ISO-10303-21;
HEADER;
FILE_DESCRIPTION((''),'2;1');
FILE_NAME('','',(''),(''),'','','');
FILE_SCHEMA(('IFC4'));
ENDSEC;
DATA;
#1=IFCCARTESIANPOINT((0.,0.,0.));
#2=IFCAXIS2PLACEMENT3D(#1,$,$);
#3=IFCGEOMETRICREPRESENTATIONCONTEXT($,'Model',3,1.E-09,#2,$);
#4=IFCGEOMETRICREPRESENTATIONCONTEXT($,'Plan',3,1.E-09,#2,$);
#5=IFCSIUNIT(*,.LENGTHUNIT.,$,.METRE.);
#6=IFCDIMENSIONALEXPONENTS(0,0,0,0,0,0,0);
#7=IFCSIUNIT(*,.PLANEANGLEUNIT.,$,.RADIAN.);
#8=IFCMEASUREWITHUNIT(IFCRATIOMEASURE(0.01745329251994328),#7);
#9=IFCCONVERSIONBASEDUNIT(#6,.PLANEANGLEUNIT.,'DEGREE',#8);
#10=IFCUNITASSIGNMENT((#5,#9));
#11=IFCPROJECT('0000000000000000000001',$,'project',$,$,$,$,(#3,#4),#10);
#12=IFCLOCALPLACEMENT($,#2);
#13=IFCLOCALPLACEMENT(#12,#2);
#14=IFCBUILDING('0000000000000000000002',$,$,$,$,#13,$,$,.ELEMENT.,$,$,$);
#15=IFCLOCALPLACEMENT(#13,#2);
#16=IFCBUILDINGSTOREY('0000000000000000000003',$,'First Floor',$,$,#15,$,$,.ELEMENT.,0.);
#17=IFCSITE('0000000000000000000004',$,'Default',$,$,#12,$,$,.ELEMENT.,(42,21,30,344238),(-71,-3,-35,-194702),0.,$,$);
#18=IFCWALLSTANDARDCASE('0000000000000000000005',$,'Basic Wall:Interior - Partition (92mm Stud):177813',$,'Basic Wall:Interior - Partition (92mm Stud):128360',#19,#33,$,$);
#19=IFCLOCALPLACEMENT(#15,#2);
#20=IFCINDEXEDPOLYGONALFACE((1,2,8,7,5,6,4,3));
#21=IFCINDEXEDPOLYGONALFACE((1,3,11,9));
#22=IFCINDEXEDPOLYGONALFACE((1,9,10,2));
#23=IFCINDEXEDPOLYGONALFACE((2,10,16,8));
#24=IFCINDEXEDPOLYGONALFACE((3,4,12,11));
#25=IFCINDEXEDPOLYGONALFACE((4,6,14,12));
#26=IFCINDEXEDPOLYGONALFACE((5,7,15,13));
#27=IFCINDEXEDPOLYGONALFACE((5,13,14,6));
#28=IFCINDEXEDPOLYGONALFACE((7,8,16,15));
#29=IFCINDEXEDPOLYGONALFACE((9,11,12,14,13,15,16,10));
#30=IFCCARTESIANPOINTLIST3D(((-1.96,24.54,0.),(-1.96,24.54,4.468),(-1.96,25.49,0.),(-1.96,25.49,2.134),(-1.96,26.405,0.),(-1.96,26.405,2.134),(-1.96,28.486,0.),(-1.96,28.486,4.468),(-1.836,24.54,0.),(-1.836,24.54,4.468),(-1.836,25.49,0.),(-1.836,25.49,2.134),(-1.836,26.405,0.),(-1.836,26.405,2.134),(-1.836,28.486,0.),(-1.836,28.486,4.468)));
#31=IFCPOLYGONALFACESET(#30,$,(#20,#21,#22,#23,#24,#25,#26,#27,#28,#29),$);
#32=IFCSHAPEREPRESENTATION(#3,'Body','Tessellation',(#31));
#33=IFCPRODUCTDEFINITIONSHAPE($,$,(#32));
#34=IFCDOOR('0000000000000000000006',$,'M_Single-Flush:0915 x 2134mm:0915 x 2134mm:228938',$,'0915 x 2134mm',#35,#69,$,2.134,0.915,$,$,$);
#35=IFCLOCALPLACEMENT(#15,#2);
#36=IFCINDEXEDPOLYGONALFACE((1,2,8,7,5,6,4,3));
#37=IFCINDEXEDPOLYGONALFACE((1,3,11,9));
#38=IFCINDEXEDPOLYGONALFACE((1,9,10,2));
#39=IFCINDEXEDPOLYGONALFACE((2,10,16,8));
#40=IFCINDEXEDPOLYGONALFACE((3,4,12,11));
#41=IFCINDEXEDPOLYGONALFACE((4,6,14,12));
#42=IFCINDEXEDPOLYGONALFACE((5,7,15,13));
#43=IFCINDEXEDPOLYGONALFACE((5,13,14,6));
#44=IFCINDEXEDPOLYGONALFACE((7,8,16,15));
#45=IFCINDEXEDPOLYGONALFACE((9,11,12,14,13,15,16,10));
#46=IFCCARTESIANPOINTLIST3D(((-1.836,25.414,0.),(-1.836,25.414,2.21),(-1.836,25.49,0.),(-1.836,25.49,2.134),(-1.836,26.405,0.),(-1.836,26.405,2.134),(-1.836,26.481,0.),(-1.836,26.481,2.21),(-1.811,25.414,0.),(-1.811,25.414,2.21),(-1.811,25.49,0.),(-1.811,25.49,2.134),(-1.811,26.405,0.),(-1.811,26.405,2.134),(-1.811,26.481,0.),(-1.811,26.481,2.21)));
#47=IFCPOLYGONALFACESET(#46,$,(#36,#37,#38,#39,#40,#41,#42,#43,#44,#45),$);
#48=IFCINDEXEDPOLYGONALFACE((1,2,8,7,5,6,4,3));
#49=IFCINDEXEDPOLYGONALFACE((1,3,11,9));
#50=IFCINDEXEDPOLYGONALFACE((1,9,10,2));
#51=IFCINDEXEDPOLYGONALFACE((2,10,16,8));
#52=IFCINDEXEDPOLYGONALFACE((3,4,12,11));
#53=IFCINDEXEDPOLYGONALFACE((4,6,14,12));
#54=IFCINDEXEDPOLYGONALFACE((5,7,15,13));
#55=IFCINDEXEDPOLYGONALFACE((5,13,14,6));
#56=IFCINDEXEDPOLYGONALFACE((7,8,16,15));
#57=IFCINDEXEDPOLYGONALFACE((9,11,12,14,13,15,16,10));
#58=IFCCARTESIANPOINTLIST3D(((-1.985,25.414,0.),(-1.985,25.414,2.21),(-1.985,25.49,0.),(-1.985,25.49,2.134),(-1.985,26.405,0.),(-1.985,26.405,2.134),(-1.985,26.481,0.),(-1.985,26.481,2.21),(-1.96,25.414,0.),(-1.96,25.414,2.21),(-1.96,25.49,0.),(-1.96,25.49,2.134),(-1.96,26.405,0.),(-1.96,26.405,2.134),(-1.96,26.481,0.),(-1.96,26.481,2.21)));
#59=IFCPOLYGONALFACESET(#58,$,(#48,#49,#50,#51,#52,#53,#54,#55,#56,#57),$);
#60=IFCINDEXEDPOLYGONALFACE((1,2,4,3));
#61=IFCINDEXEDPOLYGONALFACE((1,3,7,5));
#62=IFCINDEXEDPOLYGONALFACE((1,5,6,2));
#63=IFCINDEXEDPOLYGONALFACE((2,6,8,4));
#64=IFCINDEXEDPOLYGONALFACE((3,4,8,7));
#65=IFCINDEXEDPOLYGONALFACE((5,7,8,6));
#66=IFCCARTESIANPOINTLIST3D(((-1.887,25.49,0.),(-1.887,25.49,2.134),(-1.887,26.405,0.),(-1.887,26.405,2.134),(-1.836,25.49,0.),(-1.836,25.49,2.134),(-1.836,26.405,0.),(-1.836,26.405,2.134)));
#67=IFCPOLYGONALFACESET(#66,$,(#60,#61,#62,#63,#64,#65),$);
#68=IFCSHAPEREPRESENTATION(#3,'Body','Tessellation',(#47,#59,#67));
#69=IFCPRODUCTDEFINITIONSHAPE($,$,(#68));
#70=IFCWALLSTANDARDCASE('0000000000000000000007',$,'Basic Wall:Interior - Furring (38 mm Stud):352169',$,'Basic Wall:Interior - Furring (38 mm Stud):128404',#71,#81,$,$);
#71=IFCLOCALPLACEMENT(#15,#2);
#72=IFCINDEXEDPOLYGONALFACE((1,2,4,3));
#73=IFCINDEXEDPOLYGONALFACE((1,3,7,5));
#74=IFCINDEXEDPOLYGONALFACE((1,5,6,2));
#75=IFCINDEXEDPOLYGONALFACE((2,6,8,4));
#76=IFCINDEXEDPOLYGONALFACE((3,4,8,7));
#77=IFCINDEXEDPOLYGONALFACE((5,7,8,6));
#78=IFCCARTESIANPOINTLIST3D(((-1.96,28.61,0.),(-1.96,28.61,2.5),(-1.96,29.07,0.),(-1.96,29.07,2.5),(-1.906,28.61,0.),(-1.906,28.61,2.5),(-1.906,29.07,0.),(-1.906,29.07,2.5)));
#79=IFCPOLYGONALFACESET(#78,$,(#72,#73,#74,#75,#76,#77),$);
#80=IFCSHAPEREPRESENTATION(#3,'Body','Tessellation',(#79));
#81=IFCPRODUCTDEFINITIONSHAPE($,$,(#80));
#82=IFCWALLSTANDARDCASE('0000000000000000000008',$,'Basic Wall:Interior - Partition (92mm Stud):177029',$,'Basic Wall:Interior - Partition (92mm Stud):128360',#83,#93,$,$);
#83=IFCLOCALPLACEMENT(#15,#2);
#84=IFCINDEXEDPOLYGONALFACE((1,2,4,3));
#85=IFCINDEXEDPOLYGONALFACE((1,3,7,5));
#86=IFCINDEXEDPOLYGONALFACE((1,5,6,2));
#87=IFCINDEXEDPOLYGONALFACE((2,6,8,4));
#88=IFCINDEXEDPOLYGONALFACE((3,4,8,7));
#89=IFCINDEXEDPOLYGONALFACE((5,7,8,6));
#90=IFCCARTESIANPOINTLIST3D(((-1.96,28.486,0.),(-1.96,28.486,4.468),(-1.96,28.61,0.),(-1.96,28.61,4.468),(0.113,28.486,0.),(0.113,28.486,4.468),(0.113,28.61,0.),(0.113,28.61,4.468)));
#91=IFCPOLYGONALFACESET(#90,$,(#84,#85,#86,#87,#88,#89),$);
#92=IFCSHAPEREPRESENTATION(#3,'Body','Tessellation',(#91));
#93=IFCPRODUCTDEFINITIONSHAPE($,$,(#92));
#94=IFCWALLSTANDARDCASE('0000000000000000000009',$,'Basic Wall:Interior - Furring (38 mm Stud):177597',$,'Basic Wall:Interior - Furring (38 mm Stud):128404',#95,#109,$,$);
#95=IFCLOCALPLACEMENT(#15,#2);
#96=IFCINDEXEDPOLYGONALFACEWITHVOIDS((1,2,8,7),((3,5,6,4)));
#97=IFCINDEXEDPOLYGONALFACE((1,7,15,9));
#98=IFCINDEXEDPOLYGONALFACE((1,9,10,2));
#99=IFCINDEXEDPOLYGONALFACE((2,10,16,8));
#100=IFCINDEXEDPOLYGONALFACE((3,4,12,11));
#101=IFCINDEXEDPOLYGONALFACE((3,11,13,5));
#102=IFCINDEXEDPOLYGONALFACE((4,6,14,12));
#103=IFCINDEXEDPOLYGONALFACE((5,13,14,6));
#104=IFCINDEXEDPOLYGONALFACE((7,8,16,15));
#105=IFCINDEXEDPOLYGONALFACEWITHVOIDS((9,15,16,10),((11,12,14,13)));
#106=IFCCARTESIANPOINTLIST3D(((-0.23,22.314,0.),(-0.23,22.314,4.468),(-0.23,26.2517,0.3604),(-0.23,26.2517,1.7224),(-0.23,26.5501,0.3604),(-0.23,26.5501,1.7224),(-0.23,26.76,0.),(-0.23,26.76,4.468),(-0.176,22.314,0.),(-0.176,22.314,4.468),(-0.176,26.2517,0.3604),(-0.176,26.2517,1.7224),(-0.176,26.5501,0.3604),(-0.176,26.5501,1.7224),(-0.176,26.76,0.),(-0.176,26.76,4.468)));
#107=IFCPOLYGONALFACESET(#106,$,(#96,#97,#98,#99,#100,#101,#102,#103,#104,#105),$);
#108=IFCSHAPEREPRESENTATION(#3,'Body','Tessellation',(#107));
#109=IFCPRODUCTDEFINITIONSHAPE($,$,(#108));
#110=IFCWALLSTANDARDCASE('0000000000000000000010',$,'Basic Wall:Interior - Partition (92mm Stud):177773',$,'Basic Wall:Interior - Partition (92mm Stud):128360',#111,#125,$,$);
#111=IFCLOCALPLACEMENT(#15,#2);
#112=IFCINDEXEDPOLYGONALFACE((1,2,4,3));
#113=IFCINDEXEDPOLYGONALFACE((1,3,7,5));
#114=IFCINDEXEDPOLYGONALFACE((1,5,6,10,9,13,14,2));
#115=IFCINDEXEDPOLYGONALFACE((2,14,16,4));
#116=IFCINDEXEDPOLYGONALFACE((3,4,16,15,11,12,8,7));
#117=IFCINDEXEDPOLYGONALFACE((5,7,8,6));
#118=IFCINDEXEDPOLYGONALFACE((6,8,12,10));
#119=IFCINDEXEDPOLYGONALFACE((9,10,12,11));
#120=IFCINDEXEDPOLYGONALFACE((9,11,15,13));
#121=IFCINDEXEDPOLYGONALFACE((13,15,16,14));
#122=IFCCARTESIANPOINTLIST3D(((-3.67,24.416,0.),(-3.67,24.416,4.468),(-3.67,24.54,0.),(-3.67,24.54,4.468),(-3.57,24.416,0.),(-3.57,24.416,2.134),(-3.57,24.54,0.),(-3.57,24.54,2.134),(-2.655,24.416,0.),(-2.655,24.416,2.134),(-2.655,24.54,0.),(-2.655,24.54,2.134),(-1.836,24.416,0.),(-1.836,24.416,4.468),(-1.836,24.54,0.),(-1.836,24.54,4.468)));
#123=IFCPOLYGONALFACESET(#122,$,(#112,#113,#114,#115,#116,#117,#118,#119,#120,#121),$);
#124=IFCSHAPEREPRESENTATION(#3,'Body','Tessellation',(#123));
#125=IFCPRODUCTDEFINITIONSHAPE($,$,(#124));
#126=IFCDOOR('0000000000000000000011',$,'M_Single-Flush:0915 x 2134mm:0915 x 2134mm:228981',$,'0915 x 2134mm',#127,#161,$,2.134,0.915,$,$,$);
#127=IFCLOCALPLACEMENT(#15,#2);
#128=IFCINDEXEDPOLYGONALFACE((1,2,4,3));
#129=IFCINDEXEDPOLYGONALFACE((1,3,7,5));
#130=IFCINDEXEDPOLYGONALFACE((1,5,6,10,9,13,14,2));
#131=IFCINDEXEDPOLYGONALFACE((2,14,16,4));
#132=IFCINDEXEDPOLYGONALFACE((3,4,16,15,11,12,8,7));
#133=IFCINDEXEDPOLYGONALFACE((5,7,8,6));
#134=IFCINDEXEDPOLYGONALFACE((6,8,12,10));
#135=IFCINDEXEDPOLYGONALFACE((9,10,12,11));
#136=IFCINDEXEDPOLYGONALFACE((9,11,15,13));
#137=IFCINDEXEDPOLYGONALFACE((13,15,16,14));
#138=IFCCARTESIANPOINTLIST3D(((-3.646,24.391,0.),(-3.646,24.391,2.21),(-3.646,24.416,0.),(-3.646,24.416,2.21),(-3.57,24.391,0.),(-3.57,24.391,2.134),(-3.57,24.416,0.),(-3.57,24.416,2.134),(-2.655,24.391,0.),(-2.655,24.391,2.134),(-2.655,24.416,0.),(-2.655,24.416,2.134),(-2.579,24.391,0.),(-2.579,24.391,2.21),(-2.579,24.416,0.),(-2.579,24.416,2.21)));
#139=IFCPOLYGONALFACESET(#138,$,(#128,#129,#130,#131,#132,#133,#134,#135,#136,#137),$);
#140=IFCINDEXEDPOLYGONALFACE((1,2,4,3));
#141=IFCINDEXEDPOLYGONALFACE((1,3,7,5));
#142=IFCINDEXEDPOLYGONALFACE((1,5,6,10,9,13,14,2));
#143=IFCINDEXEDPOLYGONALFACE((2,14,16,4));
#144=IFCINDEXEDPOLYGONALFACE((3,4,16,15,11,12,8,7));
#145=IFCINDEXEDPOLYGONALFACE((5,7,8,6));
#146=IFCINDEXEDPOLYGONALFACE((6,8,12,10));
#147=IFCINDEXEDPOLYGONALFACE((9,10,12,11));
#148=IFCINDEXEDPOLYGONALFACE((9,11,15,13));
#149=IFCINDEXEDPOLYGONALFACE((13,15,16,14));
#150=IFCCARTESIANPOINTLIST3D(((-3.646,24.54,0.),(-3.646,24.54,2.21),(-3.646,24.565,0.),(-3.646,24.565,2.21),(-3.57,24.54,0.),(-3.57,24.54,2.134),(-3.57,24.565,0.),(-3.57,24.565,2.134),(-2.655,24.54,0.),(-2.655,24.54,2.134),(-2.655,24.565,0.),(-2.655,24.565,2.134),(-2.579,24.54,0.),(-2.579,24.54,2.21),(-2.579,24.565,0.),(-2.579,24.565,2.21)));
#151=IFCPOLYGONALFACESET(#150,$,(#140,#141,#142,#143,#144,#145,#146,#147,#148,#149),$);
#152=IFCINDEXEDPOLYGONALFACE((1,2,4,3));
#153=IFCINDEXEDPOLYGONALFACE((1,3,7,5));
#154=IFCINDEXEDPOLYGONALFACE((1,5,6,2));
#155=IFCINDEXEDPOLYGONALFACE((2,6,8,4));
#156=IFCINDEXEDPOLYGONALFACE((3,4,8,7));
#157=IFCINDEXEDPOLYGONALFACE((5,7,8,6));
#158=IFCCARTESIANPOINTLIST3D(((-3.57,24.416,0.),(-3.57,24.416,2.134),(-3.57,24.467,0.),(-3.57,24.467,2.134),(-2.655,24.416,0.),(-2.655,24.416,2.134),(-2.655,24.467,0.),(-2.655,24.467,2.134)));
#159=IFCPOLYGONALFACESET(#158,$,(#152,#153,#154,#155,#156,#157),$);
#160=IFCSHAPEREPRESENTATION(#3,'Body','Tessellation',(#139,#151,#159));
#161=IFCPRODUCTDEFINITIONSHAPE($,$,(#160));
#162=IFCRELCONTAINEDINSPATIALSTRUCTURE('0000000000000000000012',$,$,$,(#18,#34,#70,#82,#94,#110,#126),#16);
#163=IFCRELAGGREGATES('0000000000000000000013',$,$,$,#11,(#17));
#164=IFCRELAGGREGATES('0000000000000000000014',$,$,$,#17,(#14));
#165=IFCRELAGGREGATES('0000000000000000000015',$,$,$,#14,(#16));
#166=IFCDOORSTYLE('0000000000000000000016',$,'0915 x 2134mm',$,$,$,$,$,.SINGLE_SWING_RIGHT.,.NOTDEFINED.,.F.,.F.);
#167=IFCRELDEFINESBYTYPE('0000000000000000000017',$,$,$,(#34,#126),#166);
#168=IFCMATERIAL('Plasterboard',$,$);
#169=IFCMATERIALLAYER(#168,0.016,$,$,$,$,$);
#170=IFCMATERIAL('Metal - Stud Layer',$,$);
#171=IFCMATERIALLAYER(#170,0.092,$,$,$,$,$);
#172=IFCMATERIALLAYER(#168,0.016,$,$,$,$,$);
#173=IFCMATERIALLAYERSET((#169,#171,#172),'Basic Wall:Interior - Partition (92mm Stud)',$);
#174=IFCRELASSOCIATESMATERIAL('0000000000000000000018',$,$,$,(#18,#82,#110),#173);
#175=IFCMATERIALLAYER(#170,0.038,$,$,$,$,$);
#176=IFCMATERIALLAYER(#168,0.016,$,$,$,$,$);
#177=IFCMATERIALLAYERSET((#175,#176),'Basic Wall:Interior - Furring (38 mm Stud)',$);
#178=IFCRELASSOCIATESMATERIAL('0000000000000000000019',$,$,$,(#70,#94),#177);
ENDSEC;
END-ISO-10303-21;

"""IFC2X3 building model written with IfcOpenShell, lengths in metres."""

from ifc_helpers import new_model, entity, si_unit, converted_unit, frame, frame_2d, origin, origin_2d_with_axis, place, context, project, spatial, polyline, rectangle, outline, extrude, source, transform, mapped, material, layer, layer_set, layer_usage, type_object, type_shapes, element, fill, save


model = new_model("IFC2X3")

# Units and contexts
model_context = context("Model", 3, precision=1e-09, world=origin())
plan_context = context("Plan", 3, precision=1e-09, world=origin())
ifc_project = project(units=[si_unit("LENGTHUNIT", "METRE"), converted_unit("PLANEANGLEUNIT", "DEGREE", entity("IfcRatioMeasure", 0.01745329251994328), si_unit("PLANEANGLEUNIT", "RADIAN"), dimensions=[0, 0, 0, 0, 0, 0, 0])], contexts=[model_context, plan_context])

# Site, building, storey
site_placement = place(None, origin())
site = spatial("IfcSite", under=ifc_project, at=site_placement, Name="Default", CompositionType="ELEMENT", RefLatitude=(42, 21, 30, 344238), RefLongitude=(-71, -3, -35, -194702), RefElevation=0.0)
building_placement = place(site_placement, origin())
building = spatial("IfcBuilding", under=site, at=building_placement, CompositionType="ELEMENT")
storey_placement = place(building_placement, origin())
storey = spatial("IfcBuildingStorey", under=building, at=storey_placement, Name="First Floor", CompositionType="ELEMENT", Elevation=0.0)

# Wall, opening, door
ifc_material_1 = material(Name="Plasterboard")
ifc_layer_1 = layer(ifc_material_1, 0.016)
ifc_material_2 = material(Name="Metal - Stud Layer")
ifc_layer_2 = layer(ifc_material_2, 0.092)
ifc_layer_3 = layer(ifc_material_1, 0.016)
ifc_layer_set_1 = layer_set([ifc_layer_1, ifc_layer_2, ifc_layer_3], Name="Basic Wall:Interior - Partition (92mm Stud)")
ifc_layer_usage_1 = layer_usage(ifc_layer_set_1, "AXIS2", "NEGATIVE", 0.062)
wall_1_placement = place(storey_placement, frame((-1.898, 24.54, 0.0), z_axis=(0.0, 0.0, 1.0), x_axis=(0.0, 1.0, 0.0)))
wall_1 = element("IfcWallStandardCase", 1, at=wall_1_placement, inside=storey, material=ifc_layer_usage_1, Name="Basic Wall:Interior - Partition (92mm Stud):177813", ObjectType="Basic Wall:Interior - Partition (92mm Stud):128360", context=model_context, shape_type="SweptSolid", body=[
    extrude(rectangle(XDim=3.946, YDim=0.124, at=frame_2d((1.973, 0.0), x_axis=(-1.0, 0.0))), origin(), (0.0, 0.0, 1.0), 4.468),
])
opening_1_placement = place(wall_1_placement, frame((1.865, 0.062, 0.0)))
opening_1 = element("IfcOpeningElement", 2, at=opening_1_placement, cuts=wall_1, ObjectType="Opening", context=model_context, shape_type="SweptSolid", body=[
    extrude(rectangle(XDim=0.915, YDim=2.134, at=frame_2d((1.067, 0.4575), x_axis=(0.0, 1.0))), frame((0.0, 0.0, 0.0), z_axis=(0.0, -1.0, 0.0), x_axis=(0.0, 0.0, 1.0)), (0.0, 0.0, 1.0), 0.124),
])
door_style = type_object("IfcDoorStyle", Name="0915 x 2134mm", ConstructionType="NOTDEFINED", OperationType="SINGLE_SWING_RIGHT", ParameterTakesPrecedence=False, Sizeable=False)
shared_shape_1 = source(origin(), model_context, "Body", "SweptSolid", [
    extrude(outline(polyline([(-0.5335, -1.124), (0.5335, -1.124), (0.5335, 1.086), (0.4575, 1.086), (0.4575, -1.048), (-0.4575, -1.048), (-0.4575, 1.086), (-0.5335, 1.086), (-0.5335, -1.124)])), frame((0.4575, 0.124, 1.086), z_axis=(0.0, 1.0, 0.0), x_axis=(1.0, 0.0, 0.0)), (0.0, 0.0, 1.0), 0.025),
    extrude(outline(polyline([(-1.124, -0.5335), (1.086, -0.5335), (1.086, -0.4575), (-1.048, -0.4575), (-1.048, 0.4575), (1.086, 0.4575), (1.086, 0.5335), (-1.124, 0.5335), (-1.124, -0.5335)])), frame((0.4575, -0.025, 1.086), z_axis=(0.0, 1.0, 0.0), x_axis=(0.0, 0.0, -1.0)), (0.0, 0.0, 1.0), 0.025),
    extrude(rectangle(XDim=0.051, YDim=0.915, at=origin_2d_with_axis()), frame((0.4575, 0.0985, 0.0), z_axis=(0.0, 0.0, 1.0), x_axis=(0.0, 1.0, 0.0)), (0.0, 0.0, 1.0), 2.134),
])
type_shapes(door_style, [shared_shape_1])
door_1_placement = place(opening_1_placement, frame((0.0, 0.0, 0.0), z_axis=(0.0, 0.0, 1.0), x_axis=(-1.0, 0.0, 0.0)))
door_1 = element("IfcDoor", 3, at=door_1_placement, inside=storey, type_object=door_style, Name="M_Single-Flush:0915 x 2134mm:0915 x 2134mm:228938", ObjectType="0915 x 2134mm", OverallHeight=2.134, OverallWidth=0.915, context=model_context, shape_type="MappedRepresentation", body=[
    mapped(shared_shape_1, transform((0.0, 0.0, 0.0), scale=1.0)),
])
fill(opening_1, door_1)

# Walls
ifc_layer_4 = layer(ifc_material_2, 0.038)
ifc_layer_5 = layer(ifc_material_1, 0.016)
ifc_layer_set_2 = layer_set([ifc_layer_4, ifc_layer_5], Name="Basic Wall:Interior - Furring (38 mm Stud)")
ifc_layer_usage_2 = layer_usage(ifc_layer_set_2, "AXIS2", "POSITIVE", -0.027)
wall_2_placement = place(storey_placement, frame((-1.933, 28.61, 0.0), z_axis=(0.0, 0.0, 1.0), x_axis=(0.0, 1.0, 0.0)))
element("IfcWallStandardCase", 4, at=wall_2_placement, inside=storey, material=ifc_layer_usage_2, Name="Basic Wall:Interior - Furring (38 mm Stud):352169", ObjectType="Basic Wall:Interior - Furring (38 mm Stud):128404", context=model_context, shape_type="SweptSolid", body=[
    extrude(rectangle(XDim=0.46, YDim=0.054, at=frame_2d((0.23, 0.0), x_axis=(-1.0, 0.0))), origin(), (0.0, 0.0, 1.0), 2.5),
])
wall_3_placement = place(storey_placement, frame((-1.96, 28.548, 0.0)))
element("IfcWallStandardCase", 5, at=wall_3_placement, inside=storey, material=ifc_layer_usage_1, Name="Basic Wall:Interior - Partition (92mm Stud):177029", ObjectType="Basic Wall:Interior - Partition (92mm Stud):128360", context=model_context, shape_type="SweptSolid", body=[
    extrude(rectangle(XDim=2.073, YDim=0.124, at=frame_2d((1.0365, 0.0), x_axis=(-1.0, 0.0))), origin(), (0.0, 0.0, 1.0), 4.468),
])

# Wall, opening
wall_4_placement = place(storey_placement, frame((-0.203, 22.314, 0.0), z_axis=(0.0, 0.0, 1.0), x_axis=(0.0, 1.0, 0.0)))
wall_4 = element("IfcWallStandardCase", 6, at=wall_4_placement, inside=storey, material=ifc_layer_usage_2, Name="Basic Wall:Interior - Furring (38 mm Stud):177597", ObjectType="Basic Wall:Interior - Furring (38 mm Stud):128404", context=model_context, shape_type="SweptSolid", body=[
    extrude(rectangle(XDim=4.446, YDim=0.054, at=frame_2d((2.223, 0.0), x_axis=(-1.0, 0.0))), origin(), (0.0, 0.0, 1.0), 4.468),
])
opening_2_placement = place(wall_4_placement, origin())
element("IfcOpeningElement", 7, at=opening_2_placement, cuts=wall_4, ObjectType="Opening", context=model_context, shape_type="SweptSolid", body=[
    extrude(rectangle(XDim=1.3621, YDim=0.2985, at=frame_2d((0.0, 0.0), x_axis=(0.0, 1.0))), frame((4.0869, -0.0619, 1.0414), z_axis=(0.0, 1.0, 0.0), x_axis=(1.0, 0.0, 0.0)), (0.0, 0.0, 1.0), 0.1524),
])

# Wall, opening, door
wall_5_placement = place(storey_placement, frame((-3.67, 24.478, 0.0)))
wall_5 = element("IfcWallStandardCase", 8, at=wall_5_placement, inside=storey, material=ifc_layer_usage_1, Name="Basic Wall:Interior - Partition (92mm Stud):177773", ObjectType="Basic Wall:Interior - Partition (92mm Stud):128360", context=model_context, shape_type="SweptSolid", body=[
    extrude(rectangle(XDim=1.834, YDim=0.124, at=frame_2d((0.917, 0.0), x_axis=(-1.0, 0.0))), origin(), (0.0, 0.0, 1.0), 4.468),
])
opening_3_placement = place(wall_5_placement, frame((1.015, 0.062, 0.0)))
opening_3 = element("IfcOpeningElement", 9, at=opening_3_placement, cuts=wall_5, ObjectType="Opening", context=model_context, shape_type="SweptSolid", body=[
    extrude(rectangle(XDim=0.915, YDim=2.134, at=frame_2d((1.067, 0.4575), x_axis=(0.0, 1.0))), frame((0.0, 0.0, 0.0), z_axis=(0.0, -1.0, 0.0), x_axis=(0.0, 0.0, 1.0)), (0.0, 0.0, 1.0), 0.124),
])
door_2_placement = place(opening_3_placement, frame((0.0, 0.0, 0.0), z_axis=(0.0, 0.0, 1.0), x_axis=(-1.0, 0.0, 0.0)))
door_2 = element("IfcDoor", 10, at=door_2_placement, inside=storey, type_object=door_style, Name="M_Single-Flush:0915 x 2134mm:0915 x 2134mm:228981", ObjectType="0915 x 2134mm", OverallHeight=2.134, OverallWidth=0.915, context=model_context, shape_type="MappedRepresentation", body=[
    mapped(shared_shape_1, transform((0.0, 0.0, 0.0), scale=1.0)),
])
fill(opening_3, door_2)

save(model, "model.ifc")
